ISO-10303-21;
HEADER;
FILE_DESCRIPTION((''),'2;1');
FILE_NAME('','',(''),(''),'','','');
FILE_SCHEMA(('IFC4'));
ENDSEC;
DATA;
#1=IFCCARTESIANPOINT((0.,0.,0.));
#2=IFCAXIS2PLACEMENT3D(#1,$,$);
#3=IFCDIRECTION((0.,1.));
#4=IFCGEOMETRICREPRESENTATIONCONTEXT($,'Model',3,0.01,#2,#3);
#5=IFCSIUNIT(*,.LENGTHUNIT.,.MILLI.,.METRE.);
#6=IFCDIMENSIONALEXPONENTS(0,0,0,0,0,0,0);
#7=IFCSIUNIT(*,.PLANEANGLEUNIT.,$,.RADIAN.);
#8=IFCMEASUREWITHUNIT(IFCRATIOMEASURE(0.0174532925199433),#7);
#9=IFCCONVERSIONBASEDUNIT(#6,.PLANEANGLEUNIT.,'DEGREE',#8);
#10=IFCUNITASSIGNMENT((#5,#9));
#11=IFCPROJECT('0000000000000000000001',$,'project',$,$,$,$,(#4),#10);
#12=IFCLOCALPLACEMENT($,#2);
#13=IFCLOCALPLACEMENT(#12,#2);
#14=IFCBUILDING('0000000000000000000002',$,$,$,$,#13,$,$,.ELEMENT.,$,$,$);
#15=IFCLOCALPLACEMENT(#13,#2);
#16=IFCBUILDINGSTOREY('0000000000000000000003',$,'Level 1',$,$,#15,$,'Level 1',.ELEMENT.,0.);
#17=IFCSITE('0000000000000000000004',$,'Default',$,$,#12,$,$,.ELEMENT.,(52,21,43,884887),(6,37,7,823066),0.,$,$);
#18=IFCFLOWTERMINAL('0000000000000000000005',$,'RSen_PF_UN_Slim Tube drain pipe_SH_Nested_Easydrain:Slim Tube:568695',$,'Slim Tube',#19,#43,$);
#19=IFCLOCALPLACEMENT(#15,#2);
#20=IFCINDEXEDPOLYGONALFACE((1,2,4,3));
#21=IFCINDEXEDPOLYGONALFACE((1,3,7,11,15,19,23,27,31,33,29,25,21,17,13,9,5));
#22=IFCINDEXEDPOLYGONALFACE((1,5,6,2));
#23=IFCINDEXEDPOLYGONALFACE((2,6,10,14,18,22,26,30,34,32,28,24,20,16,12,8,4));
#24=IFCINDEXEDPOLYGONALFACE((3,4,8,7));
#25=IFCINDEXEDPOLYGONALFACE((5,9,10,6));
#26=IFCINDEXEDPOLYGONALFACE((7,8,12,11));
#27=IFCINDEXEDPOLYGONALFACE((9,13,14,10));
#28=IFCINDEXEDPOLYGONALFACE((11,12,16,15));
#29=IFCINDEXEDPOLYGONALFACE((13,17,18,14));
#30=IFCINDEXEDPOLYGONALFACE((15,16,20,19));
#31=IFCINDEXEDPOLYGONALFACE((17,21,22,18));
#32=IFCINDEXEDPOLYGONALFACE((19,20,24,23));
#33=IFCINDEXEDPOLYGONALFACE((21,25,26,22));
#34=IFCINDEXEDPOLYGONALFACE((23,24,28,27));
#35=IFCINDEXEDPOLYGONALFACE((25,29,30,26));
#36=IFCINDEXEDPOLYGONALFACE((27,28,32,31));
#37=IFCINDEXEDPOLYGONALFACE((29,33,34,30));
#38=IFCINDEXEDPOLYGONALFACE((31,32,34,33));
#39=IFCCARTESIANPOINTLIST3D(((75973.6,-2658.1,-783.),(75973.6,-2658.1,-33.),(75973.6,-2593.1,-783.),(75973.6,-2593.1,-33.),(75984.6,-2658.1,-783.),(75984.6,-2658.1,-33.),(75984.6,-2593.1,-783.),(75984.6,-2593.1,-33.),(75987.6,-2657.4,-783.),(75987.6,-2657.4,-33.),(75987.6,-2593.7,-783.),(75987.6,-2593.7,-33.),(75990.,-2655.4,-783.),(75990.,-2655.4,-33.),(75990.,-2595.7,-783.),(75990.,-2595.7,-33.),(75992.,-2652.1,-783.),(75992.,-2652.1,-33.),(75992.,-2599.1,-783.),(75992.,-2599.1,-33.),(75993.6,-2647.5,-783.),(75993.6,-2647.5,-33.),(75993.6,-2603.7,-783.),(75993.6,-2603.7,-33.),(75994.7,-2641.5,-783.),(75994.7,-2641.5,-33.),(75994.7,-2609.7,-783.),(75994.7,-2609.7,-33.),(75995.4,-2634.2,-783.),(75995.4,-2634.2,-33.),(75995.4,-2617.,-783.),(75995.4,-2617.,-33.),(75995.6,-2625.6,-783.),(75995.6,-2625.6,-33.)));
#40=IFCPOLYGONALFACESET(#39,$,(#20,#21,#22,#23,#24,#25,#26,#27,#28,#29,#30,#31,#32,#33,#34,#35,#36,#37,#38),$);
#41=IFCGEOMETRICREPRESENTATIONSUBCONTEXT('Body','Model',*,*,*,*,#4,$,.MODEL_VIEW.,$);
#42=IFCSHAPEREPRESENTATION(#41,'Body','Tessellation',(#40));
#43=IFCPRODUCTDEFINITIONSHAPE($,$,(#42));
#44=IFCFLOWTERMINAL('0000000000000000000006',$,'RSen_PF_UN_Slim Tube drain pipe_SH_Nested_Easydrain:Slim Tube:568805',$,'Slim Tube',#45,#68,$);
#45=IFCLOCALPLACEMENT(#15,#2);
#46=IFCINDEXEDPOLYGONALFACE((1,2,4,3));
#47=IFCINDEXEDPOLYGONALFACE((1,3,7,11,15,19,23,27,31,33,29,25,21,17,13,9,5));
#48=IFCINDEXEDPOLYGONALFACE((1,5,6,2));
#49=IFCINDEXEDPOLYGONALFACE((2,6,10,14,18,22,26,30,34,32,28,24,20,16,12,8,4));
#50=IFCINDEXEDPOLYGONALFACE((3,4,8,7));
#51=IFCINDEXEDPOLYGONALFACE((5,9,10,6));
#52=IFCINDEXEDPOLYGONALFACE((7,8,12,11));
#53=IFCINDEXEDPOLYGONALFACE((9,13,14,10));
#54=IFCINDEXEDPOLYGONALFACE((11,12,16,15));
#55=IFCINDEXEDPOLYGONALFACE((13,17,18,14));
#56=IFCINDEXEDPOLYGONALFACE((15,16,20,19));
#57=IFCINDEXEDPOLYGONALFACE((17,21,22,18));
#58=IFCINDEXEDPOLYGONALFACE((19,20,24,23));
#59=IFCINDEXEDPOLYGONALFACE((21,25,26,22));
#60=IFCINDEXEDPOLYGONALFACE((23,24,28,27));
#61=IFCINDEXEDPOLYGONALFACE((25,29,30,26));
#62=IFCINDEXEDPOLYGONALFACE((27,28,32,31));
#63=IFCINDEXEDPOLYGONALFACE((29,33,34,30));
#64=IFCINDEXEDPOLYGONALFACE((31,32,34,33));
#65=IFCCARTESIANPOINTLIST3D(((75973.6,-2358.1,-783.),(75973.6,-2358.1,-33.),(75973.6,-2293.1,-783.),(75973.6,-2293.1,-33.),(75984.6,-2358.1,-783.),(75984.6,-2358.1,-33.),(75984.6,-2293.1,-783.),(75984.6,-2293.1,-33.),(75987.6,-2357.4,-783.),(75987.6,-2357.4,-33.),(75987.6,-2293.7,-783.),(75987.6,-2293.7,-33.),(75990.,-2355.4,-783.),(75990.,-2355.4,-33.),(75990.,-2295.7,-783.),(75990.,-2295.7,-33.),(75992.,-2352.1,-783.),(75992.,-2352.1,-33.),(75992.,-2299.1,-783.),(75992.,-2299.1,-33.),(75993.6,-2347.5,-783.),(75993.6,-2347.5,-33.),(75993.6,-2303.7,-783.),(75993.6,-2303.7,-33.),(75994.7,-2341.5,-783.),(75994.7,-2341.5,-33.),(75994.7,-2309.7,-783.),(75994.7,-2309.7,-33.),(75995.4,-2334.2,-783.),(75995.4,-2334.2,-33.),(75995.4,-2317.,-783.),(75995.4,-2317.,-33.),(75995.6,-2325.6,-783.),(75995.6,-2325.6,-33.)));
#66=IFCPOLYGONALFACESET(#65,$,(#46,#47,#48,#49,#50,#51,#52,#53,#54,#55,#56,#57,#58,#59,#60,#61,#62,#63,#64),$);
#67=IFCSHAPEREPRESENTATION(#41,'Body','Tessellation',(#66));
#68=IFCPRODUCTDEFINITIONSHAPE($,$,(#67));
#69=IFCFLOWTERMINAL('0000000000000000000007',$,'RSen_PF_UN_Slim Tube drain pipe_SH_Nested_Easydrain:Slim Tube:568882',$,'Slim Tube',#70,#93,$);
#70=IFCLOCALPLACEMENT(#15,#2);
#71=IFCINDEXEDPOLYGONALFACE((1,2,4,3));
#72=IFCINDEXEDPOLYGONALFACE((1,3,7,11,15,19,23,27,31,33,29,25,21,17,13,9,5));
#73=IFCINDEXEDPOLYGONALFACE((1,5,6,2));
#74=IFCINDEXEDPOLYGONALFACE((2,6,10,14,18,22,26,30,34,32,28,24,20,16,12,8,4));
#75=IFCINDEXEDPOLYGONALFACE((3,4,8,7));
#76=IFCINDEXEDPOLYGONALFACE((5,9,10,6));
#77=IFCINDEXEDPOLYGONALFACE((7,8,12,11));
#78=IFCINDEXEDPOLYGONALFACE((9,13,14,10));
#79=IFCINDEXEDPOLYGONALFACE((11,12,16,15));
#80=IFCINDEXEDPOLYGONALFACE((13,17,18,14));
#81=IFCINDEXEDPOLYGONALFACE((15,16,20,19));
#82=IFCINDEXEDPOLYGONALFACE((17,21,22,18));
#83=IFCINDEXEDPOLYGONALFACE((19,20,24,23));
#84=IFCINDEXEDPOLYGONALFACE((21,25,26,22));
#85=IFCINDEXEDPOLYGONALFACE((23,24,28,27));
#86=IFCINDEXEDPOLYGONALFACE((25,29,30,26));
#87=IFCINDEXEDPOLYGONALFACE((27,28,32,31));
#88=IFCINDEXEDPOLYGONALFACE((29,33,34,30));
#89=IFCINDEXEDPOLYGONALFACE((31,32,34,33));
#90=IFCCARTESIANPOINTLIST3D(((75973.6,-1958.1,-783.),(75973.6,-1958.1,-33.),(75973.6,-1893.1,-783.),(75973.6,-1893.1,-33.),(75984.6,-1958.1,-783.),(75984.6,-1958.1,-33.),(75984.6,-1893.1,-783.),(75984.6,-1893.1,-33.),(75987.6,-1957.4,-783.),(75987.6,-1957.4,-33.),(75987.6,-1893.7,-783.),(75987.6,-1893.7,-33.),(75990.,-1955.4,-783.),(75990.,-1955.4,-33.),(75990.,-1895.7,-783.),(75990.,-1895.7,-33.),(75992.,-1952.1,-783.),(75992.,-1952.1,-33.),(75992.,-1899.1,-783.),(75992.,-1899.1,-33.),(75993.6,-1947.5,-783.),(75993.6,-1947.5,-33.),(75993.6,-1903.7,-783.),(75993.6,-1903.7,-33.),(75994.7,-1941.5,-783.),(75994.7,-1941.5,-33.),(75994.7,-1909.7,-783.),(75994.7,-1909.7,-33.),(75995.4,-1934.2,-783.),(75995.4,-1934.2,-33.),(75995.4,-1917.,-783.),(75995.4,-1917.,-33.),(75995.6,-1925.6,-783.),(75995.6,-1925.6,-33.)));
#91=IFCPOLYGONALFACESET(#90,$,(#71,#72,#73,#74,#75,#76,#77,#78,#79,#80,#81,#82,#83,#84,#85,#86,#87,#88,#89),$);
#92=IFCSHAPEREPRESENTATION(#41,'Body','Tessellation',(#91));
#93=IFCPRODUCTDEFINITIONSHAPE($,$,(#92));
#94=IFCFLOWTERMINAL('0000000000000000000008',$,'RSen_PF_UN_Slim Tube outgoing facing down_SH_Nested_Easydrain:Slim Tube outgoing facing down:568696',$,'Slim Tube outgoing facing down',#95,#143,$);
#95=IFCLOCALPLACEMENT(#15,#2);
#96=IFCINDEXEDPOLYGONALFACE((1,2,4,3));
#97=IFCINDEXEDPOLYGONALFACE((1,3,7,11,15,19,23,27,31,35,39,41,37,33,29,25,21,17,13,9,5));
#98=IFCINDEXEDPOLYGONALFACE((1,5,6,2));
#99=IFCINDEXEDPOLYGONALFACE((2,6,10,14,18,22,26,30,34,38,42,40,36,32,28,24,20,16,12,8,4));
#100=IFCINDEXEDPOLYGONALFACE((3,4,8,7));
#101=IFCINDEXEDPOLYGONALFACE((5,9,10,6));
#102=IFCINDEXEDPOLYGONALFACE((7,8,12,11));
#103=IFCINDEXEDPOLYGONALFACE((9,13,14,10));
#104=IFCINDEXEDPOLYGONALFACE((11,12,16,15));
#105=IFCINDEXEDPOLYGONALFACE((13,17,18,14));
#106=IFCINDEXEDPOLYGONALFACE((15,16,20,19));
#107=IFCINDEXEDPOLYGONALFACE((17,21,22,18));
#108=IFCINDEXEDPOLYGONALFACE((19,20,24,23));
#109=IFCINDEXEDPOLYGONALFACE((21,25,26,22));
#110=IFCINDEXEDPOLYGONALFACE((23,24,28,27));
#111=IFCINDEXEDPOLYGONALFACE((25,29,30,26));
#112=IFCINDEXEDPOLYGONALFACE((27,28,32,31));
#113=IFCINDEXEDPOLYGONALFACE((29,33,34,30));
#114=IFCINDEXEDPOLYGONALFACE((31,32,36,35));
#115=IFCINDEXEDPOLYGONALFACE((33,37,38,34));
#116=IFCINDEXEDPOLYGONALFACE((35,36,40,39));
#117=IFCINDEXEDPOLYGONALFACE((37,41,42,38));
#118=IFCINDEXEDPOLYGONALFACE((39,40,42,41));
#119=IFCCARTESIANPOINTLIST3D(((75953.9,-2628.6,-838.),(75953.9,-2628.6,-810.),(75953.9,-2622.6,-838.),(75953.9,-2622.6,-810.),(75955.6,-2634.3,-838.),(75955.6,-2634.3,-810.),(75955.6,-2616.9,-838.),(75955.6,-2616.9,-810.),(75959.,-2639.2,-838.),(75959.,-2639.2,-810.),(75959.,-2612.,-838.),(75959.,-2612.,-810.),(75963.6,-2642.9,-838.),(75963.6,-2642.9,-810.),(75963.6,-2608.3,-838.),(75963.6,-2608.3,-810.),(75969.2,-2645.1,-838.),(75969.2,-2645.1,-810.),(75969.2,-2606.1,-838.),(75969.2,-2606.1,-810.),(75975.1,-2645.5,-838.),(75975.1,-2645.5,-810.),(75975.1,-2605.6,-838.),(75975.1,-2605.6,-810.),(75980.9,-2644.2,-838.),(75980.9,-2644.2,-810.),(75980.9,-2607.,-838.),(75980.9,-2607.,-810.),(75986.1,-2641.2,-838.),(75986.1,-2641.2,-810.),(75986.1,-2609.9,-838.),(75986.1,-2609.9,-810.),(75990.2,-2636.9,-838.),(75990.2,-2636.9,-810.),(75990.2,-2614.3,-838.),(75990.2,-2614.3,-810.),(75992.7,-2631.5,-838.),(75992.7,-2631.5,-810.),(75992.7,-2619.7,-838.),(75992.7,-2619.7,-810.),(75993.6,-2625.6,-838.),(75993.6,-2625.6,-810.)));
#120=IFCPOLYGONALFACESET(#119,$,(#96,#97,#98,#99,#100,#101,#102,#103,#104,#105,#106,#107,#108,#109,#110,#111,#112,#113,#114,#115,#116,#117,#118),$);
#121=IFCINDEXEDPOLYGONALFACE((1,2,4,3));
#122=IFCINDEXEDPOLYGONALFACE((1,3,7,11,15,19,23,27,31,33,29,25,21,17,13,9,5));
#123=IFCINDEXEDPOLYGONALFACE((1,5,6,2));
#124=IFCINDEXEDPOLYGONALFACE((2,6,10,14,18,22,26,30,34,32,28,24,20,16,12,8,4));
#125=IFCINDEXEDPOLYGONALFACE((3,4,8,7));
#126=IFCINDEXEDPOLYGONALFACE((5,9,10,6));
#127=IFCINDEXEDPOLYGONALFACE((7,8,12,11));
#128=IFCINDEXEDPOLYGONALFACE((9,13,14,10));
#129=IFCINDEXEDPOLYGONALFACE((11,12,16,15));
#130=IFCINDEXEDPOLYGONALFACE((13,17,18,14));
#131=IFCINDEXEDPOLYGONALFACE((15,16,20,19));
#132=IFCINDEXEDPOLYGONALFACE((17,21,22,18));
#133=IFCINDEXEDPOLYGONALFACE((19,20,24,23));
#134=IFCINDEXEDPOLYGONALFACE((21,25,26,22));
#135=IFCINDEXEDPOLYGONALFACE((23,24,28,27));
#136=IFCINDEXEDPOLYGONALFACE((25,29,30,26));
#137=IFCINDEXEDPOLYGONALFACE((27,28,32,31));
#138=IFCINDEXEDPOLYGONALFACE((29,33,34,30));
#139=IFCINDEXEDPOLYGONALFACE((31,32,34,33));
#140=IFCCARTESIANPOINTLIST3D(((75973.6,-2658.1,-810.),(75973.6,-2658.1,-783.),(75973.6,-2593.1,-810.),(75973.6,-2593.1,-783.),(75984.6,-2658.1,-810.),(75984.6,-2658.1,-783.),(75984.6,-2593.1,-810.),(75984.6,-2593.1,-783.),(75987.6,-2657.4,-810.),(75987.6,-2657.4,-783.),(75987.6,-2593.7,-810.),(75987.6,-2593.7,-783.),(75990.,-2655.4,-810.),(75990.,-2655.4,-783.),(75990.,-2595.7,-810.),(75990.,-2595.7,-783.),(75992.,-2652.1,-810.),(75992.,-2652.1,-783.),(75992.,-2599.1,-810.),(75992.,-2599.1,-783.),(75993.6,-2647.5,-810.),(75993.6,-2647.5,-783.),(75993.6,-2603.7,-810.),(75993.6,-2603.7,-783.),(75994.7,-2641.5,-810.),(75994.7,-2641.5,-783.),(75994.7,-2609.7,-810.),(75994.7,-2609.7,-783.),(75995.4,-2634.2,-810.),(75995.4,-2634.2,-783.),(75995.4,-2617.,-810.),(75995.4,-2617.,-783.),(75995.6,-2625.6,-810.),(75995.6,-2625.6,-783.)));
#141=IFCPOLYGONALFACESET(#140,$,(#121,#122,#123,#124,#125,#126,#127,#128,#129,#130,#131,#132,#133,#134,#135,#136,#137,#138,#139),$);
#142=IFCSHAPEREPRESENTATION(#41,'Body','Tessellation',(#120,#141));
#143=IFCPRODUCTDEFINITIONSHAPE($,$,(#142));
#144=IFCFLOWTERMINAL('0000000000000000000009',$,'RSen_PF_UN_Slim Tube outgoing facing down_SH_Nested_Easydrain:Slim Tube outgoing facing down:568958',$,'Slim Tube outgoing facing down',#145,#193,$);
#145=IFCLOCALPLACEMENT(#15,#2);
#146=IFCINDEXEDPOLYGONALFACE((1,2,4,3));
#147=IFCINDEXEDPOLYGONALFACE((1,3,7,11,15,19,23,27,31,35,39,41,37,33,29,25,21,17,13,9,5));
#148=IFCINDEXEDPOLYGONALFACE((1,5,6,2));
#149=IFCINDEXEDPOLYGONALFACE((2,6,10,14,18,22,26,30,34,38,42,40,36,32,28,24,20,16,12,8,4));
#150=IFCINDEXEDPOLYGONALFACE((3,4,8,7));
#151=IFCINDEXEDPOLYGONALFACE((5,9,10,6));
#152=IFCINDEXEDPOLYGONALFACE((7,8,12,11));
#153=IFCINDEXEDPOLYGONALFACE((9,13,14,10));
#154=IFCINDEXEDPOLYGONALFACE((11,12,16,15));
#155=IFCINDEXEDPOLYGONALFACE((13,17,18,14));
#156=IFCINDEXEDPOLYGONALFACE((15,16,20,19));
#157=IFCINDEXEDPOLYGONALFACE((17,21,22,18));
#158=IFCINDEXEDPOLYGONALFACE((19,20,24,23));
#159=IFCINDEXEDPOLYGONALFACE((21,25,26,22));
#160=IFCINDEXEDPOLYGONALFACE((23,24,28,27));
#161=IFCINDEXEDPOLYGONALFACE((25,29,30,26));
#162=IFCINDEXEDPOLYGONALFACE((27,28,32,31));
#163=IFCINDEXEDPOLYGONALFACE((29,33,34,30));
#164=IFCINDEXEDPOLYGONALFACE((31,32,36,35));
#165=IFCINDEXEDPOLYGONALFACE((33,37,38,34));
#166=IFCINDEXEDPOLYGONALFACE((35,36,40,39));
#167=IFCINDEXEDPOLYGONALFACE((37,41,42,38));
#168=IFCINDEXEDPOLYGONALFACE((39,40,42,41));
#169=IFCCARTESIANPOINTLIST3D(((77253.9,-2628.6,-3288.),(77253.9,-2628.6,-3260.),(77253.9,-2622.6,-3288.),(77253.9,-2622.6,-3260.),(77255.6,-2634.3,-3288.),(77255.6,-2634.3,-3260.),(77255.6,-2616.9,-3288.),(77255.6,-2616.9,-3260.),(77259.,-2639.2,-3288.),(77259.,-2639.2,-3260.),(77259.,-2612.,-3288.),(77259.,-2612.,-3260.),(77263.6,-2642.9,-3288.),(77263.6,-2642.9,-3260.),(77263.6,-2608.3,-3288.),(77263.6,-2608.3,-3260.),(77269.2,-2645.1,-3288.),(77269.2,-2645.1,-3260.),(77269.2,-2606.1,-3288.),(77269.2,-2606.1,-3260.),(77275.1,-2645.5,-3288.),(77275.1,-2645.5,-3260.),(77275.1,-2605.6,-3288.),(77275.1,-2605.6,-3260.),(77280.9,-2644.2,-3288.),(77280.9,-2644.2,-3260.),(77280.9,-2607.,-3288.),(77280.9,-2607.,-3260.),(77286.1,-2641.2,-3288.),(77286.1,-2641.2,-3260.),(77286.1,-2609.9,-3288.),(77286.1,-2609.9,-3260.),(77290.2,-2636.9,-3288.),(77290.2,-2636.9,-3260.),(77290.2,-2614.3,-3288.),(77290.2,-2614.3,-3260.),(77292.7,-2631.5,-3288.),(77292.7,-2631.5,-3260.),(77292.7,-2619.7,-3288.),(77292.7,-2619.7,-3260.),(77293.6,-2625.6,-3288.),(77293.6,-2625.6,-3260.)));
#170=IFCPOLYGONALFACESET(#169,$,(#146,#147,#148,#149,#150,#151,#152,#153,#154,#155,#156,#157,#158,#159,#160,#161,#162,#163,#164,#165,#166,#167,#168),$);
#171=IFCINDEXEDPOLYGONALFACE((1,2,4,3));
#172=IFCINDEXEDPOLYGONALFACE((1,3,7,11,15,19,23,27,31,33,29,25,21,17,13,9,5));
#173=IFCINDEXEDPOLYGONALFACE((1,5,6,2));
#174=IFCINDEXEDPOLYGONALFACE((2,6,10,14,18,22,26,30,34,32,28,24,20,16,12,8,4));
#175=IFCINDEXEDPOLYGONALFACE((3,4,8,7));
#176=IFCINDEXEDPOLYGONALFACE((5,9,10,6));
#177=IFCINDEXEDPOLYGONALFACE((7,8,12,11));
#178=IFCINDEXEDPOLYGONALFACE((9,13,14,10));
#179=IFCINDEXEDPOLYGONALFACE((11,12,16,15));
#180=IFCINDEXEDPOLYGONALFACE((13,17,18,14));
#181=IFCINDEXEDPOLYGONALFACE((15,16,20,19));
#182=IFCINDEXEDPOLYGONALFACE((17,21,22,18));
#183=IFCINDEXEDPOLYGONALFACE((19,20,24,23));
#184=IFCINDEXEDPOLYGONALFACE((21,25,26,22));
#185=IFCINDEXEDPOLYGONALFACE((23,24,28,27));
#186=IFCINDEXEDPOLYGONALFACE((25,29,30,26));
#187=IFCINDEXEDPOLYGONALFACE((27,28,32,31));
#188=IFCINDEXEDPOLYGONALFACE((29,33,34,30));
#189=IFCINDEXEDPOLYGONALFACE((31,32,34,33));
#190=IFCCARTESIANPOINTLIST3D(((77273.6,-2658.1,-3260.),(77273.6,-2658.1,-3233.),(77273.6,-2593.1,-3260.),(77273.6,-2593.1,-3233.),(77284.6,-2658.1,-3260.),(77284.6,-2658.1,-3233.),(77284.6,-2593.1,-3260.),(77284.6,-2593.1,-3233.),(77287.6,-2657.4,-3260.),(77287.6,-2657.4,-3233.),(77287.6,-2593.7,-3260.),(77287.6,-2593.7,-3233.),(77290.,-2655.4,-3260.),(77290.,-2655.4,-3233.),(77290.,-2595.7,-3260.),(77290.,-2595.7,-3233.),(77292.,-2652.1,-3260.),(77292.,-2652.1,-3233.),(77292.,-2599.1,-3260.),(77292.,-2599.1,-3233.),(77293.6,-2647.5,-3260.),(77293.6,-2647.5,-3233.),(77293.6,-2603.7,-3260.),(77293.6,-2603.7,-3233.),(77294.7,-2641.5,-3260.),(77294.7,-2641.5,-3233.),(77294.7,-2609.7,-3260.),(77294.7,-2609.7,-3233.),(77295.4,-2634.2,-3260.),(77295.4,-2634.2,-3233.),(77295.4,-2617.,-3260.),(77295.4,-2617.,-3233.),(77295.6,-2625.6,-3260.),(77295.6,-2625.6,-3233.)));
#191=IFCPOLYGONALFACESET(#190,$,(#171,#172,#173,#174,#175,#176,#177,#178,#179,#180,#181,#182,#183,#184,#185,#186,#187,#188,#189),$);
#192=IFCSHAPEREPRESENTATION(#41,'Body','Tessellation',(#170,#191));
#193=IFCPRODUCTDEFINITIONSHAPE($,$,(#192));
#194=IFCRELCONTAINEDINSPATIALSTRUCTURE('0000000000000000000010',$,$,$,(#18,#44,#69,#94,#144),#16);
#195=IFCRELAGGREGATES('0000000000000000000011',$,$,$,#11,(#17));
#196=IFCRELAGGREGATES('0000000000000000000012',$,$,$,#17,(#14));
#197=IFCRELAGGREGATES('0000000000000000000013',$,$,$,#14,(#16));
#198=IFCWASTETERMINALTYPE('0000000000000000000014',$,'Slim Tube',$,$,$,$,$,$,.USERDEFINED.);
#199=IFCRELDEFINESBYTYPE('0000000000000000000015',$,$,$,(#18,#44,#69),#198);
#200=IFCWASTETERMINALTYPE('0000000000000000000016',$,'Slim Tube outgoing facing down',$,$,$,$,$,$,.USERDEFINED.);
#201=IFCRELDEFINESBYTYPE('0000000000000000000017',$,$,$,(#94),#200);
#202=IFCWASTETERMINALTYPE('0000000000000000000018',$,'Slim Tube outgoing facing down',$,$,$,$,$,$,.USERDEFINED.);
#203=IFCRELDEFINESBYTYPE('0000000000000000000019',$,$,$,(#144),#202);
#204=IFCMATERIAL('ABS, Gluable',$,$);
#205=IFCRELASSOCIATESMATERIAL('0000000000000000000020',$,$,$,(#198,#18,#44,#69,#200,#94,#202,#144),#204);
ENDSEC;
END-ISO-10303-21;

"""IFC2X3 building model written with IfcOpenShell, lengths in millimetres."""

from ifc_helpers import new_model, entity, si_unit, converted_unit, direction, frame, frame_2d, origin, place, context, subcontext, project, spatial, polyline, circle, outline, extrude, source, transform, mapped, material, type_object, type_shapes, element, save


model = new_model("IFC2X3")

# Units and contexts
model_context = context("Model", 3, precision=0.01, world=origin(), true_north=direction((0.0, 1.0)))
body_context = subcontext(model_context, "Body", "Model", "MODEL_VIEW")
ifc_project = project(units=[si_unit("LENGTHUNIT", "METRE", prefix="MILLI"), converted_unit("PLANEANGLEUNIT", "DEGREE", entity("IfcRatioMeasure", 0.0174532925199433), si_unit("PLANEANGLEUNIT", "RADIAN"), dimensions=[0, 0, 0, 0, 0, 0, 0])], contexts=[model_context])

# Site, building, storey
site_placement = place(None, origin())
site = spatial("IfcSite", under=ifc_project, at=site_placement, Name="Default", CompositionType="ELEMENT", RefLatitude=(52, 21, 43, 884887), RefLongitude=(6, 37, 7, 823066), RefElevation=0.0)
building_placement = place(site_placement, origin())
building = spatial("IfcBuilding", under=site, at=building_placement, CompositionType="ELEMENT")
storey_placement = place(building_placement, origin())
storey = spatial("IfcBuildingStorey", under=building, at=storey_placement, Name="Level 1", LongName="Level 1", CompositionType="ELEMENT", Elevation=0.0)

# Flow terminals
ifc_material_1 = material(Name="ABS, Gluable")
waste_terminal_type_1 = type_object("IfcWasteTerminalType", Name="Slim Tube", PredefinedType="USERDEFINED", material=ifc_material_1)
shared_shape_1 = source(origin(), body_context, "Body", "SweptSolid", [
    extrude(outline(polyline([(4.7, -32.5), (15.7, -32.5), (15.7, 32.5), (4.7, 32.5), (1.8, 31.8), (-0.7, 29.8), (-2.7, 26.5), (-4.3, 21.9), (-5.4, 15.9), (-6.1, 8.6), (-6.3, 0.0), (-6.1, -8.6), (-5.4, -15.9), (-4.3, -21.9), (-2.7, -26.5), (-0.7, -29.8), (1.8, -31.8), (4.7, -32.5)])), frame((4.7, 0.0, -750.0), z_axis=(0.0, 0.0, 1.0), x_axis=(-1.0, 0.0, 0.0)), (0.0, 0.0, 1.0), 750.0),
])
type_shapes(waste_terminal_type_1, [shared_shape_1])
for number, where, name in (
    (1, (75984.6, -2625.6, -33.0), "RSen_PF_UN_Slim Tube drain pipe_SH_Nested_Easydrain:Slim Tube:568695"),
    (2, (75984.6, -2325.6, -33.0), "RSen_PF_UN_Slim Tube drain pipe_SH_Nested_Easydrain:Slim Tube:568805"),
    (3, (75984.6, -1925.6, -33.0), "RSen_PF_UN_Slim Tube drain pipe_SH_Nested_Easydrain:Slim Tube:568882"),
):
    element("IfcFlowTerminal", number, at=place(storey_placement, frame(where)), inside=storey, type_object=waste_terminal_type_1, material=ifc_material_1, Name=name, ObjectType="Slim Tube", context=body_context, shape_type="MappedRepresentation", body=[
        mapped(shared_shape_1, transform((0.0, 0.0, 0.0), scale=1.0)),
    ])
waste_terminal_type_2 = type_object("IfcWasteTerminalType", Name="Slim Tube outgoing facing down", PredefinedType="USERDEFINED", material=ifc_material_1)
shared_shape_2 = source(origin(), body_context, "Body", "SweptSolid", [
    extrude(circle(Radius=20.0, at=frame_2d((0.0, 0.0), x_axis=(1.0, 0.0))), frame((-11.0, 0.0, -838.0)), (0.0, 0.0, 1.0), 28.0),
    extrude(outline(polyline([(4.7, -32.5), (15.7, -32.5), (15.7, 32.5), (4.7, 32.5), (1.8, 31.8), (-0.7, 29.8), (-2.7, 26.5), (-4.3, 21.9), (-5.4, 15.9), (-6.1, 8.6), (-6.3, 0.0), (-6.1, -8.6), (-5.4, -15.9), (-4.3, -21.9), (-2.7, -26.5), (-0.7, -29.8), (1.8, -31.8), (4.7, -32.5)])), frame((4.7, 0.0, -810.0), z_axis=(0.0, 0.0, 1.0), x_axis=(-1.0, 0.0, 0.0)), (0.0, 0.0, 1.0), 27.0),
])
type_shapes(waste_terminal_type_2, [shared_shape_2])
flow_terminal_1_placement = place(storey_placement, frame((75984.6, -2625.6, 0.0)))
element("IfcFlowTerminal", 4, at=flow_terminal_1_placement, inside=storey, type_object=waste_terminal_type_2, material=ifc_material_1, Name="RSen_PF_UN_Slim Tube outgoing facing down_SH_Nested_Easydrain:Slim Tube outgoing facing down:568696", ObjectType="Slim Tube outgoing facing down", context=body_context, shape_type="MappedRepresentation", body=[
    mapped(shared_shape_2, transform((0.0, 0.0, 0.0), scale=1.0)),
])
waste_terminal_type_3 = type_object("IfcWasteTerminalType", Name="Slim Tube outgoing facing down", PredefinedType="USERDEFINED", material=ifc_material_1)
shared_shape_3 = source(origin(), body_context, "Body", "SweptSolid", [
    extrude(circle(Radius=20.0, at=frame_2d((0.0, 0.0), x_axis=(1.0, 0.0))), frame((-11.0, 0.0, -3288.0)), (0.0, 0.0, 1.0), 28.0),
    extrude(outline(polyline([(4.7, -32.5), (15.7, -32.5), (15.7, 32.5), (4.7, 32.5), (1.8, 31.8), (-0.7, 29.8), (-2.7, 26.5), (-4.3, 21.9), (-5.4, 15.9), (-6.1, 8.6), (-6.3, 0.0), (-6.1, -8.6), (-5.4, -15.9), (-4.3, -21.9), (-2.7, -26.5), (-0.7, -29.8), (1.8, -31.8), (4.7, -32.5)])), frame((4.7, 0.0, -3260.0), z_axis=(0.0, 0.0, 1.0), x_axis=(-1.0, 0.0, 0.0)), (0.0, 0.0, 1.0), 27.0),
])
type_shapes(waste_terminal_type_3, [shared_shape_3])
flow_terminal_2_placement = place(storey_placement, frame((77284.6, -2625.6, 0.0)))
element("IfcFlowTerminal", 5, at=flow_terminal_2_placement, inside=storey, type_object=waste_terminal_type_3, material=ifc_material_1, Name="RSen_PF_UN_Slim Tube outgoing facing down_SH_Nested_Easydrain:Slim Tube outgoing facing down:568958", ObjectType="Slim Tube outgoing facing down", context=body_context, shape_type="MappedRepresentation", body=[
    mapped(shared_shape_3, transform((0.0, 0.0, 0.0), scale=1.0)),
])

save(model, "model.ifc")
